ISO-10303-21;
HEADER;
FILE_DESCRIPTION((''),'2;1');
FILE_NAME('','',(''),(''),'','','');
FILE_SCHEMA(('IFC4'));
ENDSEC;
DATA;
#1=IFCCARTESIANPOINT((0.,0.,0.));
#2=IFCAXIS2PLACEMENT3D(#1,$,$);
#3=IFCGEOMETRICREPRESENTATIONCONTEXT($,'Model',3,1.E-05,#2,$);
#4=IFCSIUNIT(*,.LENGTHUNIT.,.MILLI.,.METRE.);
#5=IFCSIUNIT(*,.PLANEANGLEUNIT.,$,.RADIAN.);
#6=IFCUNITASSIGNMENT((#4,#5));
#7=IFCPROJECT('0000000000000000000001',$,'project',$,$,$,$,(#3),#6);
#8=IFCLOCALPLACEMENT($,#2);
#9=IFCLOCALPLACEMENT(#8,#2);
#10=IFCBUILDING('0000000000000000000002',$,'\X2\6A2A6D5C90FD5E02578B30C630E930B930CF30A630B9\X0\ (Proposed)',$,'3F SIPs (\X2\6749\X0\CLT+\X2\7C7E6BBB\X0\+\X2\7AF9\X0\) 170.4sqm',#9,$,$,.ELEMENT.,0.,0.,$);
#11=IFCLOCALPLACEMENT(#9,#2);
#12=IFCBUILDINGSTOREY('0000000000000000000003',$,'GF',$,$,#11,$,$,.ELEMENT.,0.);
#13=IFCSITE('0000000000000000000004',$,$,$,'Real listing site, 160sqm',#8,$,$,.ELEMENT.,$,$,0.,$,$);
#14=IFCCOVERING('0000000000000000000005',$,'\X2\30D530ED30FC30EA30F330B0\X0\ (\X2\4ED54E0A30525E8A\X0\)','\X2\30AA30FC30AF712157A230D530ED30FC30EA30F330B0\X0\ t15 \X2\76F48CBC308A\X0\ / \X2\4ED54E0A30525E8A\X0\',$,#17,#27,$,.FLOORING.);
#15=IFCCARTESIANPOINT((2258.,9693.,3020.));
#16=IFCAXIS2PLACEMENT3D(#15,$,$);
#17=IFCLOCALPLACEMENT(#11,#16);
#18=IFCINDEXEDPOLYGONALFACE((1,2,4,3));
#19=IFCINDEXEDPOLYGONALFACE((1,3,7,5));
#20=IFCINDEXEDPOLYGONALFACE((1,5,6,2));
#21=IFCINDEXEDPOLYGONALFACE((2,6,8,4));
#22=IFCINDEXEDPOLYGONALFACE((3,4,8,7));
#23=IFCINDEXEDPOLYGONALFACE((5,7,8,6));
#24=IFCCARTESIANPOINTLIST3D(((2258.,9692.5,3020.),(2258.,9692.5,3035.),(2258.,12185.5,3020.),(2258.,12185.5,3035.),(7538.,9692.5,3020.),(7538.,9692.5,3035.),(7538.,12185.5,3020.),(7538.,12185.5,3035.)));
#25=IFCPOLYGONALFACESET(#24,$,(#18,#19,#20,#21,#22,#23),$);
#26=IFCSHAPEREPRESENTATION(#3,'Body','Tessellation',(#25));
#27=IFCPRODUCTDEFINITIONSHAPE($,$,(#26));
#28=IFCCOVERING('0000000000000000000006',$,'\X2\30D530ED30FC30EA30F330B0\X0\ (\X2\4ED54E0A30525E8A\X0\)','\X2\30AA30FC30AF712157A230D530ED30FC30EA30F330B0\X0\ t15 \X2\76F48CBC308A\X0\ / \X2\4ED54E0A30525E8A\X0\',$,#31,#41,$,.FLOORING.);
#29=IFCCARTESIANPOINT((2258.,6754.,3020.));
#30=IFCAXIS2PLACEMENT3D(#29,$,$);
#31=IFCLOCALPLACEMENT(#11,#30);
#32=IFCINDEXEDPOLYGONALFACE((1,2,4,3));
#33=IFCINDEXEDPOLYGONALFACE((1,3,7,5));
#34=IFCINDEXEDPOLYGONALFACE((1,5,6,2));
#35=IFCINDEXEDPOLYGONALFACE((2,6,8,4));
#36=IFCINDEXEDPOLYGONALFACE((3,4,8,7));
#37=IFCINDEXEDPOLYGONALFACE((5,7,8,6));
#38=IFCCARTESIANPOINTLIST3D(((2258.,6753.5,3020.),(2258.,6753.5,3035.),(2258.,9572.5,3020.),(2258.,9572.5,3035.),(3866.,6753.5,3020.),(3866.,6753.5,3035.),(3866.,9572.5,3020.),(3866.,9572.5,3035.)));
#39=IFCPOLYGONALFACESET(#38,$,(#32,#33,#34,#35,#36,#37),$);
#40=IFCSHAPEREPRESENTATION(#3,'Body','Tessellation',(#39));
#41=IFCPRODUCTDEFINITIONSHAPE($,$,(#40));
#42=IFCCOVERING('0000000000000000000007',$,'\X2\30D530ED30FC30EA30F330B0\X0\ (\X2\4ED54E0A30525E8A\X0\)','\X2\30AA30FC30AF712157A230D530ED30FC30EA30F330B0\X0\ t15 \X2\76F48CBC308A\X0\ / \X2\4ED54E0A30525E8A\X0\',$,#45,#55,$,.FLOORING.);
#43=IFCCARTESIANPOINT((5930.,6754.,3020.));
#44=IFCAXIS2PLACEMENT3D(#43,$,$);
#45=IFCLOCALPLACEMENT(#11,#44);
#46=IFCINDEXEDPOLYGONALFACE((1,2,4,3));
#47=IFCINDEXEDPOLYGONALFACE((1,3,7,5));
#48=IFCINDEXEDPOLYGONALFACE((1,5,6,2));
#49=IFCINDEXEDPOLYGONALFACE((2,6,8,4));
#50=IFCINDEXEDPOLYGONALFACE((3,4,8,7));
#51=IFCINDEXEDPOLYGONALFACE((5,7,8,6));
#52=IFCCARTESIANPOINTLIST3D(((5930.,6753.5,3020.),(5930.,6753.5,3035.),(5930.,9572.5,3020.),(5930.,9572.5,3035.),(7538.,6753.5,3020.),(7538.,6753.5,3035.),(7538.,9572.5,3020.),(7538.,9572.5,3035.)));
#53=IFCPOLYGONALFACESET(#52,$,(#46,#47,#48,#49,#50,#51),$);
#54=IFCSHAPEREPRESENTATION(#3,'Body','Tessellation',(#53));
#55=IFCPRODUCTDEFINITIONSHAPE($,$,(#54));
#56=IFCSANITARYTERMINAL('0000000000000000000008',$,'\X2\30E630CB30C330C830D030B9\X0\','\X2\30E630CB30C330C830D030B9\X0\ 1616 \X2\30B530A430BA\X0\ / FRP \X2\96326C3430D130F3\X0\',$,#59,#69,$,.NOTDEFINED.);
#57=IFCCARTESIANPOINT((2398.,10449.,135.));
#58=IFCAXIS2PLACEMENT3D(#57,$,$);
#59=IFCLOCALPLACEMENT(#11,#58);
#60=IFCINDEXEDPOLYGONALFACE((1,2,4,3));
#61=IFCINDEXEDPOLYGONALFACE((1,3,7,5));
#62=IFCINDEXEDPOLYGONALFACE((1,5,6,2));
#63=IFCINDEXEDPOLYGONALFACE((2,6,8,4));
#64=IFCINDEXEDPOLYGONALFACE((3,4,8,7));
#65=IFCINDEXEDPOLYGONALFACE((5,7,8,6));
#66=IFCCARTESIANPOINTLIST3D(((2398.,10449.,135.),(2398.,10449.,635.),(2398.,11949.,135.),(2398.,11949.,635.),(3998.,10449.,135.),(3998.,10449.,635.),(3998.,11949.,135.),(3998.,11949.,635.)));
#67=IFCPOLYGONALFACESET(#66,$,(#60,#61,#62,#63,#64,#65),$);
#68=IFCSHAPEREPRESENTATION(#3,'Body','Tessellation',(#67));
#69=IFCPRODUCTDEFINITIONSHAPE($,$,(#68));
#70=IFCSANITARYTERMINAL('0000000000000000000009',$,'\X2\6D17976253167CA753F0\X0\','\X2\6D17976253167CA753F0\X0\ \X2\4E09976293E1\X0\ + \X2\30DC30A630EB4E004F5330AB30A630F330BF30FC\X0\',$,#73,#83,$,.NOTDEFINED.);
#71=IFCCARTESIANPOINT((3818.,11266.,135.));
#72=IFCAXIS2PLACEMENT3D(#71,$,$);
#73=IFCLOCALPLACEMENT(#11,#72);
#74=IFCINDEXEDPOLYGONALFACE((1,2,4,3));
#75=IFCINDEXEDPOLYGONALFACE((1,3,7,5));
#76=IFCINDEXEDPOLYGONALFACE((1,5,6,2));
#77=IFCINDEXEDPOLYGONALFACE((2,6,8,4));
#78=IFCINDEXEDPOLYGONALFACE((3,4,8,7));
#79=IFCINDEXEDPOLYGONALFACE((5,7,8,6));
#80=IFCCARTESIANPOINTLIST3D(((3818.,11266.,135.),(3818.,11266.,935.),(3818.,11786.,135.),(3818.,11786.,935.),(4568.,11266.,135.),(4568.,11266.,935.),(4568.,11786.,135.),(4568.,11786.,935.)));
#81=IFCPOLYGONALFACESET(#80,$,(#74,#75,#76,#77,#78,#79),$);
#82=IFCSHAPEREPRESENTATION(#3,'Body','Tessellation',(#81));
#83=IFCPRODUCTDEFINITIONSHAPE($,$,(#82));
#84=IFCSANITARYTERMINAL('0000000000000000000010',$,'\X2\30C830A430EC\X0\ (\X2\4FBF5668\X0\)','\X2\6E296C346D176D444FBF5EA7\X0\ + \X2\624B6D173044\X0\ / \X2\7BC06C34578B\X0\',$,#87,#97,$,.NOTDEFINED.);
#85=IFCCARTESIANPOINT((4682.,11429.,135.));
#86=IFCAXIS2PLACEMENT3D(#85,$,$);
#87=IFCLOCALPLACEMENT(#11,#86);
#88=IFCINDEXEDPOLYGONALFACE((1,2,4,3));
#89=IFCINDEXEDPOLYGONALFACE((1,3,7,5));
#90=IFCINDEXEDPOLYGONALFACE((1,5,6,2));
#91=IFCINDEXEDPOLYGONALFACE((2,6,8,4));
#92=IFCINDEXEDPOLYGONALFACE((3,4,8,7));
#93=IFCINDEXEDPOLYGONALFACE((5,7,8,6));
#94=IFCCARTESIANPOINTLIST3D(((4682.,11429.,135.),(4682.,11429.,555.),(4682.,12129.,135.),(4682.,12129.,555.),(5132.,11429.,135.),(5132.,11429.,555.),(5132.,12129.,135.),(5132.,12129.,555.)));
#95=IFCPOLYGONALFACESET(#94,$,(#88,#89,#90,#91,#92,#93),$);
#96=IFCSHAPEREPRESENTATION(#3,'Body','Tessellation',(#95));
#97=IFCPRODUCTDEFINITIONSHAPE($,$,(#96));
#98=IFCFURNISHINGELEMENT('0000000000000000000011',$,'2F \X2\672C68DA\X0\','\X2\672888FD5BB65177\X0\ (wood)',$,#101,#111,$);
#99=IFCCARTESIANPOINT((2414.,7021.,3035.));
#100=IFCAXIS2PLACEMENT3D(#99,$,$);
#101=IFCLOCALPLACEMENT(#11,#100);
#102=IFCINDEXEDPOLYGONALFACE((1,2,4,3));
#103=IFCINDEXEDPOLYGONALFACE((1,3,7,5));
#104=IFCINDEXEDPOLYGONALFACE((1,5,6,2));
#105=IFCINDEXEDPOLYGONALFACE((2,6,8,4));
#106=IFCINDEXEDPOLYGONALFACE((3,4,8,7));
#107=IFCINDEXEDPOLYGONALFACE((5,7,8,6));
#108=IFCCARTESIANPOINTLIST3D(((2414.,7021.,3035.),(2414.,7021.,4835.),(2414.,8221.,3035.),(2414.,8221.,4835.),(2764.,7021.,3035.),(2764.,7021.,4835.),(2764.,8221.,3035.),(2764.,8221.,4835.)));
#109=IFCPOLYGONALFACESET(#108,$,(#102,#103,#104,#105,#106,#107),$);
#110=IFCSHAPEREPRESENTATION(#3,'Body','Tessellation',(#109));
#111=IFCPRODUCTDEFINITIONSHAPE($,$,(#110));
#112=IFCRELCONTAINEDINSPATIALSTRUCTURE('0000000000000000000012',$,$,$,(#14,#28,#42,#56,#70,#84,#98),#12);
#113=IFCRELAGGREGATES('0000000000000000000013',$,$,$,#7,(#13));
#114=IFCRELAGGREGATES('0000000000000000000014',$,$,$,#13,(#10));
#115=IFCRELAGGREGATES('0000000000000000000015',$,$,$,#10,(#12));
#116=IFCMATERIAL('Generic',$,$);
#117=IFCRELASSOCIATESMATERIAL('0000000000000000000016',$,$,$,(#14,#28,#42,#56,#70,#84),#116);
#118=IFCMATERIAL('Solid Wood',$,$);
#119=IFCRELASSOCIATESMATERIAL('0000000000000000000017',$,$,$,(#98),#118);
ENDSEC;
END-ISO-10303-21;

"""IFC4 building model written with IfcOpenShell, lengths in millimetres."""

from ifc_helpers import new_model, si_unit, frame, frame_2d, origin, place, context, project, spatial, rectangle, extrude, material, element, save


model = new_model("IFC4")

# Units and contexts
model_context = context("Model", 3, precision=1e-05, world=origin())
ifc_project = project(units=[si_unit("LENGTHUNIT", "METRE", prefix="MILLI"), si_unit("PLANEANGLEUNIT", "RADIAN")], contexts=[model_context])

# Site, building, storey
site_placement = place(None, origin())
site = spatial("IfcSite", under=ifc_project, at=site_placement, ObjectType="Real listing site, 160sqm", CompositionType="ELEMENT", RefElevation=0.0)
building_placement = place(site_placement, origin())
building = spatial("IfcBuilding", under=site, at=building_placement, Name="横浜都市型テラスハウス (Proposed)", ObjectType="3F SIPs (杉CLT+籾殻+竹) 170.4sqm", CompositionType="ELEMENT", ElevationOfRefHeight=0.0, ElevationOfTerrain=0.0)
storey_placement = place(building_placement, origin())
storey = spatial("IfcBuildingStorey", under=building, at=storey_placement, Name="GF", CompositionType="ELEMENT", Elevation=0.0)

# Shared definitions
ifc_material_1 = material(Name="Solid Wood")

# Coverings
ifc_material_2 = material(Name="Generic")
covering_1_placement = place(storey_placement, frame((2258.0, 9693.0, 3020.0)))
element("IfcCovering", 1, at=covering_1_placement, inside=storey, material=ifc_material_2, Name="フローリング (仕上げ床)", Description="オーク無垢フローリング t15 直貼り / 仕上げ床", PredefinedType="FLOORING", context=model_context, shape_type="SweptSolid", body=[
    extrude(rectangle(XDim=5280.0, YDim=2493.0, at=frame_2d((2640.0, 1246.0))), frame((2258.0, 9693.0, 3020.0)), (0.0, 0.0, 1.0), 15.0),
])
covering_2_placement = place(storey_placement, frame((2258.0, 6754.0, 3020.0)))
element("IfcCovering", 2, at=covering_2_placement, inside=storey, material=ifc_material_2, Name="フローリング (仕上げ床)", Description="オーク無垢フローリング t15 直貼り / 仕上げ床", PredefinedType="FLOORING", context=model_context, shape_type="SweptSolid", body=[
    extrude(rectangle(XDim=1608.0, YDim=2819.0, at=frame_2d((804.0, 1409.0))), frame((2258.0, 6754.0, 3020.0)), (0.0, 0.0, 1.0), 15.0),
])
covering_3_placement = place(storey_placement, frame((5930.0, 6754.0, 3020.0)))
element("IfcCovering", 3, at=covering_3_placement, inside=storey, material=ifc_material_2, Name="フローリング (仕上げ床)", Description="オーク無垢フローリング t15 直貼り / 仕上げ床", PredefinedType="FLOORING", context=model_context, shape_type="SweptSolid", body=[
    extrude(rectangle(XDim=1608.0, YDim=2819.0, at=frame_2d((804.0, 1409.0))), frame((5930.0, 6754.0, 3020.0)), (0.0, 0.0, 1.0), 15.0),
])

# Sanitary terminals
sanitary_terminal_1_placement = place(storey_placement, frame((2398.0, 10449.0, 135.0)))
element("IfcSanitaryTerminal", 4, at=sanitary_terminal_1_placement, inside=storey, material=ifc_material_2, Name="ユニットバス", Description="ユニットバス 1616 サイズ / FRP 防水パン", PredefinedType="NOTDEFINED", context=model_context, shape_type="SweptSolid", body=[
    extrude(rectangle(XDim=1600.0, YDim=1500.0, at=frame_2d((800.0, 750.0))), frame((2398.0, 10449.0, 135.0)), (0.0, 0.0, 1.0), 500.0),
])
sanitary_terminal_2_placement = place(storey_placement, frame((3818.0, 11266.0, 135.0)))
element("IfcSanitaryTerminal", 5, at=sanitary_terminal_2_placement, inside=storey, material=ifc_material_2, Name="洗面化粧台", Description="洗面化粧台 三面鏡 + ボウル一体カウンター", PredefinedType="NOTDEFINED", context=model_context, shape_type="SweptSolid", body=[
    extrude(rectangle(XDim=750.0, YDim=520.0, at=frame_2d((375.0, 260.0))), frame((3818.0, 11266.0, 135.0)), (0.0, 0.0, 1.0), 800.0),
])
sanitary_terminal_3_placement = place(storey_placement, frame((4682.0, 11429.0, 135.0)))
element("IfcSanitaryTerminal", 6, at=sanitary_terminal_3_placement, inside=storey, material=ifc_material_2, Name="トイレ (便器)", Description="温水洗浄便座 + 手洗い / 節水型", PredefinedType="NOTDEFINED", context=model_context, shape_type="SweptSolid", body=[
    extrude(rectangle(XDim=450.0, YDim=700.0, at=frame_2d((225.0, 350.0))), frame((4682.0, 11429.0, 135.0)), (0.0, 0.0, 1.0), 420.0),
])

# Furnishing element
furnishing_placement = place(storey_placement, frame((2414.0, 7021.0, 3035.0)))
element("IfcFurnishingElement", 7, at=furnishing_placement, inside=storey, material=ifc_material_1, Name="2F 本棚", Description="木製家具 (wood)", context=model_context, shape_type="SweptSolid", body=[
    extrude(rectangle(XDim=350.0, YDim=1200.0, at=frame_2d((175.0, 600.0))), frame((2414.0, 7021.0, 3035.0)), (0.0, 0.0, 1.0), 1800.0),
])

save(model, "model.ifc")
